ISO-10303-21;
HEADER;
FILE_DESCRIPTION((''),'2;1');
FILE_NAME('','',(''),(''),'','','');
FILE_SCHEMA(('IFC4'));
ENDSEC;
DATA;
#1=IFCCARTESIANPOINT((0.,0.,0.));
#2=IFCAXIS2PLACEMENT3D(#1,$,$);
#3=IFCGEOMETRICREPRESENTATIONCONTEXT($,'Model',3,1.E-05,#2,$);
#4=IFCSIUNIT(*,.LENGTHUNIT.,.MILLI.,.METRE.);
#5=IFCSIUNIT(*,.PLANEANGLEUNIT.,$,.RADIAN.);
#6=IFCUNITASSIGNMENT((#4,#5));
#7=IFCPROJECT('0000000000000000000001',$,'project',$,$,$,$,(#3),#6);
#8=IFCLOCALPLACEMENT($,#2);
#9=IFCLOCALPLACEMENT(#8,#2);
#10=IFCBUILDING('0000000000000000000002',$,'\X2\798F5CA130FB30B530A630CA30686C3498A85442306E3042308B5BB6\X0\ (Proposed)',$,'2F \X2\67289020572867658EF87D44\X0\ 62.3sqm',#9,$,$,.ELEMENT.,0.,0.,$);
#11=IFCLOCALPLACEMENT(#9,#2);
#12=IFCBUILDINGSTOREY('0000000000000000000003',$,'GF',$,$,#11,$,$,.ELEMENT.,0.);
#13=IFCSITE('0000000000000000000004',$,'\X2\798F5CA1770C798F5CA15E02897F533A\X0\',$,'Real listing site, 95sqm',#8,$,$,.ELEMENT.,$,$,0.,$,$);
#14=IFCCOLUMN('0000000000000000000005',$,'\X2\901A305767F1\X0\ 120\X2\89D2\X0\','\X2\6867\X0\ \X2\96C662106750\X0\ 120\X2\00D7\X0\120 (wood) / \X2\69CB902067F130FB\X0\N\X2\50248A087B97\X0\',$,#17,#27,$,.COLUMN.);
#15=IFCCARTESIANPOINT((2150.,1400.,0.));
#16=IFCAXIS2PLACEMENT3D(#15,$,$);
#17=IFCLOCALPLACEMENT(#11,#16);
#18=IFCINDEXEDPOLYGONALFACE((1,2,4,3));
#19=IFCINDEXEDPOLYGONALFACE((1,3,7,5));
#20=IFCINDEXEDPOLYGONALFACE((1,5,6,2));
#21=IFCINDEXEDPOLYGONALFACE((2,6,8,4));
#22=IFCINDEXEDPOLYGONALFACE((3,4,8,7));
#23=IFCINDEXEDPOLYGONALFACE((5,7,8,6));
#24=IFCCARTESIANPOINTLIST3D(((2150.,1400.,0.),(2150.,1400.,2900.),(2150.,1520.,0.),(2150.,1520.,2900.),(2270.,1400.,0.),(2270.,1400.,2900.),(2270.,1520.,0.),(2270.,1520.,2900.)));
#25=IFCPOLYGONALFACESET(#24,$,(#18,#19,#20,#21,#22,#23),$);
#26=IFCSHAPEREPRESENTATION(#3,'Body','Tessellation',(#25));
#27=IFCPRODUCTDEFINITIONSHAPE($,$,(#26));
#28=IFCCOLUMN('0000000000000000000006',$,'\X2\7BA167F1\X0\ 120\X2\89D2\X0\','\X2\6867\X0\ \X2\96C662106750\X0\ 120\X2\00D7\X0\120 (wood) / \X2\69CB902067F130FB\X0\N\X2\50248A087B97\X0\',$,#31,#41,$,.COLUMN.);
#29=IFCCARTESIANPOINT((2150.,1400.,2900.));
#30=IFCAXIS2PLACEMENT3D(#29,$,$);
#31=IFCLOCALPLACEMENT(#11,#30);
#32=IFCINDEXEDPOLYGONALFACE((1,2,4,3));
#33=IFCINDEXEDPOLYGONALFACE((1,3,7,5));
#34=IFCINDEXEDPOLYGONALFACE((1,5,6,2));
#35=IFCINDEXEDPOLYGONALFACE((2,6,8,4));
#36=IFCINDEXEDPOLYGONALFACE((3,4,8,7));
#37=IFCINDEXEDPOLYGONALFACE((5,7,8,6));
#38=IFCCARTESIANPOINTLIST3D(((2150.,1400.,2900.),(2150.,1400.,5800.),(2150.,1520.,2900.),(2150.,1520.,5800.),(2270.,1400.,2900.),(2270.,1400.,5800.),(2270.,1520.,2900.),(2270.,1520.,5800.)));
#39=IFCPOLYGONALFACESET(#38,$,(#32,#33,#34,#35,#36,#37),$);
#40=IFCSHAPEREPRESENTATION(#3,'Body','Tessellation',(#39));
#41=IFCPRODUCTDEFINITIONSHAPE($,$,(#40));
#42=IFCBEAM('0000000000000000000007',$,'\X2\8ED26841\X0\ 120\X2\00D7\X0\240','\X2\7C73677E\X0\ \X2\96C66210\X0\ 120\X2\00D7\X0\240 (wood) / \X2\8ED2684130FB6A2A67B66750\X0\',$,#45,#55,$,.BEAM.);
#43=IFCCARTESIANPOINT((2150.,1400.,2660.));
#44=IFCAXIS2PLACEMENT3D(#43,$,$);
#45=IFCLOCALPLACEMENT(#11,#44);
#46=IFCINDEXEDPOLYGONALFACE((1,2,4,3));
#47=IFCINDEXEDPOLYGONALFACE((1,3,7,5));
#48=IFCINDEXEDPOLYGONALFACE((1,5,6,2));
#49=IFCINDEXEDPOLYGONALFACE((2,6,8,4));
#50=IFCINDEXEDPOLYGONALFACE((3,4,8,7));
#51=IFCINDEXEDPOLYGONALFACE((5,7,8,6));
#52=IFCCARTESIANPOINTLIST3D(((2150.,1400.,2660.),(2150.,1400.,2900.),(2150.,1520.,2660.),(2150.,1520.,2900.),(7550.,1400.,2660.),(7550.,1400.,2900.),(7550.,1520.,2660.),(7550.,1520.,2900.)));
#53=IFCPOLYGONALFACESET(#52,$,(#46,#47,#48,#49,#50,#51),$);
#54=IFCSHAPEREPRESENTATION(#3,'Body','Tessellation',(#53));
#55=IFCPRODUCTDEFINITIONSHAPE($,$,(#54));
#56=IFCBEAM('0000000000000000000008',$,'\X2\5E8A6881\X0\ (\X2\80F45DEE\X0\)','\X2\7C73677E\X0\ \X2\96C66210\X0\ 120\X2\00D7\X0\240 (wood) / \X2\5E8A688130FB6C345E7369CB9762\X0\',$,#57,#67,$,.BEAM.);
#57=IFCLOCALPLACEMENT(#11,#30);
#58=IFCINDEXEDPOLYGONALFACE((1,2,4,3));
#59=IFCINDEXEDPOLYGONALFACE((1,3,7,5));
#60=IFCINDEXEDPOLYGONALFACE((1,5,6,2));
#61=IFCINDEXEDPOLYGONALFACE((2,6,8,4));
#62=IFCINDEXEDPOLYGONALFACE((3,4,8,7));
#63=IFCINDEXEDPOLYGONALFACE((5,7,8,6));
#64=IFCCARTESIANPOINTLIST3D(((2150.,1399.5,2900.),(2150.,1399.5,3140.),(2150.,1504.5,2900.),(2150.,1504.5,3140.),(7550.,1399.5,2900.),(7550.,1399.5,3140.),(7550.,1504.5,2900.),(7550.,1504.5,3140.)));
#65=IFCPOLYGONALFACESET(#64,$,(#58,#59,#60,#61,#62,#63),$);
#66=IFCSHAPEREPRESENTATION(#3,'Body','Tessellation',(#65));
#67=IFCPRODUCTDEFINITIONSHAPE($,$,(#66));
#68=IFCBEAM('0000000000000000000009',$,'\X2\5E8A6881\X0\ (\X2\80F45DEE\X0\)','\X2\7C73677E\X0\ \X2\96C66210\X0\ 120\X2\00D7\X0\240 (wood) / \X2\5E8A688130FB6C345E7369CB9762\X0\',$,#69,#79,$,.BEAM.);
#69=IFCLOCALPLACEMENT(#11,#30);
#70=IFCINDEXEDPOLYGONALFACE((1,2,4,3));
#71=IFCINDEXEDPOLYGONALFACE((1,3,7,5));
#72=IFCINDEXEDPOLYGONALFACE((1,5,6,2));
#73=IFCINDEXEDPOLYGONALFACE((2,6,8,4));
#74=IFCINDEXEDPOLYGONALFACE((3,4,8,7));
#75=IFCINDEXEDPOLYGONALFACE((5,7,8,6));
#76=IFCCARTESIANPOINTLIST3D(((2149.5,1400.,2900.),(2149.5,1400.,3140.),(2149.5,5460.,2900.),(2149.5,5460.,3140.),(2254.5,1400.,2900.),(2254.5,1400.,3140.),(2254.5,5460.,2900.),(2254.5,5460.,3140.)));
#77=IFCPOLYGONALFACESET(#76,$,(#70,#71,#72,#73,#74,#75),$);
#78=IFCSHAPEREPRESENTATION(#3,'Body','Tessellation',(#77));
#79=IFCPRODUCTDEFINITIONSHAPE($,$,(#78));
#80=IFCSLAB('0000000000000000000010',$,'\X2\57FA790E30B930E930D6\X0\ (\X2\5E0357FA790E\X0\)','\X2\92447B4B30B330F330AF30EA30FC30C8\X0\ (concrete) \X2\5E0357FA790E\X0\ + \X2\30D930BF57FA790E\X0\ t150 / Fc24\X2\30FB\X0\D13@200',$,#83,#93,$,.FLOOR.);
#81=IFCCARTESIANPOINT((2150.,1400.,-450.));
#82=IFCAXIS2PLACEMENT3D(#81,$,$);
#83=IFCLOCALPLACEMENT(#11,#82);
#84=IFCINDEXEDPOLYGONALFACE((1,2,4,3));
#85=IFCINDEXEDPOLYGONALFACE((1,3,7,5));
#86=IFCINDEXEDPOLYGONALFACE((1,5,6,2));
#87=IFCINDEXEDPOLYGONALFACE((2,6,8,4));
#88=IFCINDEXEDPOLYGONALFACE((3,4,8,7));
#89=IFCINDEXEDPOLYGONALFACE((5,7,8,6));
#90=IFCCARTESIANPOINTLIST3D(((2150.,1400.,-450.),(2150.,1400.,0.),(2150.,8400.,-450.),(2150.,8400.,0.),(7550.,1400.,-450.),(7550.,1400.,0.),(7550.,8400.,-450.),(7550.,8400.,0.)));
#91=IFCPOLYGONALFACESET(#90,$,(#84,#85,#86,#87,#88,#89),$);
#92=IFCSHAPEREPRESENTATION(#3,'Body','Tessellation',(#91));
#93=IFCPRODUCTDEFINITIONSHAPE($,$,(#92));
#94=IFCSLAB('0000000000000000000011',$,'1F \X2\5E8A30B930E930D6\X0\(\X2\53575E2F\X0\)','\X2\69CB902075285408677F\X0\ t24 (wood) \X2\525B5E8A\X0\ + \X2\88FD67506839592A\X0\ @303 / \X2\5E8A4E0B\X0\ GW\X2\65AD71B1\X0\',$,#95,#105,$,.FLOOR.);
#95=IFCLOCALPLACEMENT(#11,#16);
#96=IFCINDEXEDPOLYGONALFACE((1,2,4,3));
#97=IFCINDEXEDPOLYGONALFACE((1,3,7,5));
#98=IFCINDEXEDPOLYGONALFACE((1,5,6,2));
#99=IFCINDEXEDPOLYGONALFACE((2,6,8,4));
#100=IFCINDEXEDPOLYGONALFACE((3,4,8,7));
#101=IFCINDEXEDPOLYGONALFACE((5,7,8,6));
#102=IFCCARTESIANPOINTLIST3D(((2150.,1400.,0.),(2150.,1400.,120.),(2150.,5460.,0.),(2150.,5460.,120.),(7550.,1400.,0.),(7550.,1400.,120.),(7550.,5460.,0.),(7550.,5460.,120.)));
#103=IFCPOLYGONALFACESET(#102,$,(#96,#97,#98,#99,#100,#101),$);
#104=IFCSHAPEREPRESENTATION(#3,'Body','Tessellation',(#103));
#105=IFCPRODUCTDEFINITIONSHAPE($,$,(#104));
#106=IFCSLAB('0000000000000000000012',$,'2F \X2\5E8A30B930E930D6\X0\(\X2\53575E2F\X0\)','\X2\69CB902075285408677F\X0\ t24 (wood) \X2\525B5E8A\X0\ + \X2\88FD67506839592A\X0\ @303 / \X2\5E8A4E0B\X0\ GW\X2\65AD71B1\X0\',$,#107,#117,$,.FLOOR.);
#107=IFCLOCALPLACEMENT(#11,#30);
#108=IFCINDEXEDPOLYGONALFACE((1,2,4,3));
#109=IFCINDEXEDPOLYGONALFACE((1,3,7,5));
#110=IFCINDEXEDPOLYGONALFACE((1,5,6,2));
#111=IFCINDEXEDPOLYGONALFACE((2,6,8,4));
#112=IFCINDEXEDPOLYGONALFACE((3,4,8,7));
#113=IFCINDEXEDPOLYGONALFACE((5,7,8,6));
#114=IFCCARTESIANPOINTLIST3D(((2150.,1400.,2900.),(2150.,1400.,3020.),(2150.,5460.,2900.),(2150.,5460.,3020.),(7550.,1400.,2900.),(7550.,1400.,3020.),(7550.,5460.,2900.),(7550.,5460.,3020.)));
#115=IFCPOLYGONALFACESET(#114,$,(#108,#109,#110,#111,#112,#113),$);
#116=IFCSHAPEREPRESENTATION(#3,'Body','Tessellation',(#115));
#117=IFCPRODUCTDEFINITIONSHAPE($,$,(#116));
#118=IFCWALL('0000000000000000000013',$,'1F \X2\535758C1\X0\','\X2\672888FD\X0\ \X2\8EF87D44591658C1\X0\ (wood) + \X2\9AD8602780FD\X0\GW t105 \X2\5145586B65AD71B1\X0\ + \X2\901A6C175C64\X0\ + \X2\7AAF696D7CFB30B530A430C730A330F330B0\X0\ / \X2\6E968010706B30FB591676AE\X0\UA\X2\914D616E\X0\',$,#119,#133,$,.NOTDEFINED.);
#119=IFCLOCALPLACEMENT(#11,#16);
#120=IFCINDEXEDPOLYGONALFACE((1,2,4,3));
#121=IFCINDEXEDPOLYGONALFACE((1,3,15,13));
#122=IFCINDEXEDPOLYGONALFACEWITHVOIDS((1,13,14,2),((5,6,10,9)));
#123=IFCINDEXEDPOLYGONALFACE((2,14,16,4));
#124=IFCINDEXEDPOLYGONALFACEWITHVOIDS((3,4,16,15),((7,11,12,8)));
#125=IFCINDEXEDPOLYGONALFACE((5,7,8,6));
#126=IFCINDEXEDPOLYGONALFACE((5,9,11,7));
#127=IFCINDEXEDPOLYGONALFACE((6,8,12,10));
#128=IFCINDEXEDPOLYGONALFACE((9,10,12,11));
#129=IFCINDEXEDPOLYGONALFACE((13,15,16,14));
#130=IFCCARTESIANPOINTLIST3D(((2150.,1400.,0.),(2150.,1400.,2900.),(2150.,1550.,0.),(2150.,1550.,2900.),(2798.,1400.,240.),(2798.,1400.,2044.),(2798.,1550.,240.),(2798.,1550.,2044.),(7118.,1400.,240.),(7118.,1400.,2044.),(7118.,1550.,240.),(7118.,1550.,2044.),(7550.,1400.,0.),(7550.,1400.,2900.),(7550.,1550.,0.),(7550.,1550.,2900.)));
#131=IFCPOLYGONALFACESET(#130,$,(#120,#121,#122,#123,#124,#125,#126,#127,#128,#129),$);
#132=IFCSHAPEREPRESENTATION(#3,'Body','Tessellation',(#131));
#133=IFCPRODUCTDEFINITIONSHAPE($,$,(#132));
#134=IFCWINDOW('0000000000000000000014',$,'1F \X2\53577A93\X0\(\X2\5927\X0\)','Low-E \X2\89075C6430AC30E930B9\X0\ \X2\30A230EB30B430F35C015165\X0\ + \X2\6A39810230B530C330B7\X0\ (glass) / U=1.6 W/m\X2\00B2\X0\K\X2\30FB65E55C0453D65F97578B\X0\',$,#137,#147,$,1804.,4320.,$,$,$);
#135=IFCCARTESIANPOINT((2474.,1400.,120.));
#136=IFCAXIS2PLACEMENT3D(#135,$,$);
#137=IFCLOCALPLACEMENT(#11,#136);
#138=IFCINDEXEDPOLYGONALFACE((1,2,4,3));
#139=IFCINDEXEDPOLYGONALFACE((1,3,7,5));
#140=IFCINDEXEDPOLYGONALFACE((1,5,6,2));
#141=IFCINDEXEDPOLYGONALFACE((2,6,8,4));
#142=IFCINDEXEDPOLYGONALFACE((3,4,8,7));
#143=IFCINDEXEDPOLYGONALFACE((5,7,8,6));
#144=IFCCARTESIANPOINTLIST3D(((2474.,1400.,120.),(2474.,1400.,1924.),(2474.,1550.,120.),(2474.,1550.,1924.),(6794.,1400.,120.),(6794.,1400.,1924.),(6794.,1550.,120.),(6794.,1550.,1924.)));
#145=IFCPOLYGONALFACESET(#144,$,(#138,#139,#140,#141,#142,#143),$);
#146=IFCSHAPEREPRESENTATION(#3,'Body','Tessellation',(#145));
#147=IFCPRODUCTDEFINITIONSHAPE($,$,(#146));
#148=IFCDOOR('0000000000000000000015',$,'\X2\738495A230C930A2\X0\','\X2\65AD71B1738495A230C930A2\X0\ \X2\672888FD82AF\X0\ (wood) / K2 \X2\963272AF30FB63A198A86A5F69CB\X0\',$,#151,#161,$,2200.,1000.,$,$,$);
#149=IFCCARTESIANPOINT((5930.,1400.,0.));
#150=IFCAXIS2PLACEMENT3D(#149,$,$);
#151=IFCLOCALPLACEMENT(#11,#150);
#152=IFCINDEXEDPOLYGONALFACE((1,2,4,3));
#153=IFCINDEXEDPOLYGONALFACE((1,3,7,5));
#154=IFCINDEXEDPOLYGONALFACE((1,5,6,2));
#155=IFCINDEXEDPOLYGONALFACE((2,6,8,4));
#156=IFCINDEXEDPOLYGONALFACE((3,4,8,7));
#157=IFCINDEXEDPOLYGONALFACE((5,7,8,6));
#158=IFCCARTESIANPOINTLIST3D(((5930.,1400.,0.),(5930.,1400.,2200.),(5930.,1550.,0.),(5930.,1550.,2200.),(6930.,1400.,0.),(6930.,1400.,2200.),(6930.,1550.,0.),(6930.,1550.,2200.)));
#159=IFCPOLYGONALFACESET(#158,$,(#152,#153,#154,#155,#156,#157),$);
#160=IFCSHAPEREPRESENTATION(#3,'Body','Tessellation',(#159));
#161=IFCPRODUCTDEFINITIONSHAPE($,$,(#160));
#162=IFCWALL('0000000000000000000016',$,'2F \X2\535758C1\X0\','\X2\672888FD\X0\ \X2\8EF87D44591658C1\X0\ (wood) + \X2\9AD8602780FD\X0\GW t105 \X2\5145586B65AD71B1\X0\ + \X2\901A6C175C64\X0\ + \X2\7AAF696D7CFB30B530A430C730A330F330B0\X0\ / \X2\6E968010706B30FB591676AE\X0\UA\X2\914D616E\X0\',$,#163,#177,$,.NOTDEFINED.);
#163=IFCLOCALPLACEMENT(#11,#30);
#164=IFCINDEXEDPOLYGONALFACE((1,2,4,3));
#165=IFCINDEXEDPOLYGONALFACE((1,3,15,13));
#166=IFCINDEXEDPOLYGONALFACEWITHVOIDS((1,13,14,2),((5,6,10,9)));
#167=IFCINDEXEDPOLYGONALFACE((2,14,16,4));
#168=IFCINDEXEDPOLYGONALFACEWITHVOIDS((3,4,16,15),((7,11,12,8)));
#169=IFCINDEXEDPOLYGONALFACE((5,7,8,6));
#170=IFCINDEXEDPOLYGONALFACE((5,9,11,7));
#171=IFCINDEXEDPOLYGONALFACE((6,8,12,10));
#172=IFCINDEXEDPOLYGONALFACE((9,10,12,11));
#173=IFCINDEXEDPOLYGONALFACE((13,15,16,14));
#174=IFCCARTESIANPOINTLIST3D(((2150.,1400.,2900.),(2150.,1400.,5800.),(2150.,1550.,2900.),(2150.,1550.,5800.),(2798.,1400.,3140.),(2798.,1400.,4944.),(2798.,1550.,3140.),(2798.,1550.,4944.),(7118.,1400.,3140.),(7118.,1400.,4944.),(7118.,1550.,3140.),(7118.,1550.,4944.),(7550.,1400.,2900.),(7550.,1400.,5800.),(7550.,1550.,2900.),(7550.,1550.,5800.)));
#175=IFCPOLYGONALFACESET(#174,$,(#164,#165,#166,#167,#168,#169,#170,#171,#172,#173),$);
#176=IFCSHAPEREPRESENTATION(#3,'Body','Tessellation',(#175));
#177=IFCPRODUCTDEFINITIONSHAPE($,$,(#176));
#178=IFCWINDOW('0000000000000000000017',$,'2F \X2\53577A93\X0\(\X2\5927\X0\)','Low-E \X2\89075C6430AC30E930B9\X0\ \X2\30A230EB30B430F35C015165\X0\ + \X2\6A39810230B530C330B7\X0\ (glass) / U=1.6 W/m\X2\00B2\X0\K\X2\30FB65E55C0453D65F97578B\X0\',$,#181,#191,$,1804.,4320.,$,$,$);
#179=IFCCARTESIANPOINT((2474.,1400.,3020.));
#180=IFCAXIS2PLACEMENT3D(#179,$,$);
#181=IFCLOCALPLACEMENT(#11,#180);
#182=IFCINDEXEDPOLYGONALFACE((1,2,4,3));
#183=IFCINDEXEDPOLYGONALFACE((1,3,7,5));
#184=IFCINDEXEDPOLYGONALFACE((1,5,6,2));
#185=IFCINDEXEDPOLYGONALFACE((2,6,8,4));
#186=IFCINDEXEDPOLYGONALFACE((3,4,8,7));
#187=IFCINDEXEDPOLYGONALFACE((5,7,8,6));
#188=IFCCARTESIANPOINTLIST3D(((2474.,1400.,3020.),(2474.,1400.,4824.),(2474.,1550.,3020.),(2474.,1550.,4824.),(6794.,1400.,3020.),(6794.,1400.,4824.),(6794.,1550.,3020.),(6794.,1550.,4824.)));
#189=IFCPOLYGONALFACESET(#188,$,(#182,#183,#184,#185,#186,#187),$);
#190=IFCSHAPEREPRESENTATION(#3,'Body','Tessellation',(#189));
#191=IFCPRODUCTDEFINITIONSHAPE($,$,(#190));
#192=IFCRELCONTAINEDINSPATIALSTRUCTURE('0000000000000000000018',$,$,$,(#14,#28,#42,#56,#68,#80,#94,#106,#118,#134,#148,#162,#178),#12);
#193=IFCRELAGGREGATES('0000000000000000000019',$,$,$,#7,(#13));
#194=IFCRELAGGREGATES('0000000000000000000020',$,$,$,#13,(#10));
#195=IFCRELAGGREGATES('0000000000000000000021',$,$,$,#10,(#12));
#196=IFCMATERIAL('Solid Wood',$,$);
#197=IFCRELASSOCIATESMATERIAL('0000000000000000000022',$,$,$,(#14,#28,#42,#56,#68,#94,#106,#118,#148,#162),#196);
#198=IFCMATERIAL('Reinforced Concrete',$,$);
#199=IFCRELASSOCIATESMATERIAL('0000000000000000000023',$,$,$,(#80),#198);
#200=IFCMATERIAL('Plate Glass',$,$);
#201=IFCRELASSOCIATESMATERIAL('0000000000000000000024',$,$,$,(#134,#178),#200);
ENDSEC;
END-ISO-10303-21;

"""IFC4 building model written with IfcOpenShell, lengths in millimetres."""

from ifc_helpers import new_model, si_unit, frame, frame_2d, origin, place, context, project, spatial, rectangle, extrude, material, element, fill, save


model = new_model("IFC4")

# Units and contexts
model_context = context("Model", 3, precision=1e-05, world=origin())
ifc_project = project(units=[si_unit("LENGTHUNIT", "METRE", prefix="MILLI"), si_unit("PLANEANGLEUNIT", "RADIAN")], contexts=[model_context])

# Site, building, storey
site_placement = place(None, origin())
site = spatial("IfcSite", under=ifc_project, at=site_placement, Name="福岡県福岡市西区", ObjectType="Real listing site, 95sqm", CompositionType="ELEMENT", RefElevation=0.0)
building_placement = place(site_placement, origin())
building = spatial("IfcBuilding", under=site, at=building_placement, Name="福岡・サウナと水風呂のある家 (Proposed)", ObjectType="2F 木造在来軸組 62.3sqm", CompositionType="ELEMENT", ElevationOfRefHeight=0.0, ElevationOfTerrain=0.0)
storey_placement = place(building_placement, origin())
storey = spatial("IfcBuildingStorey", under=building, at=storey_placement, Name="GF", CompositionType="ELEMENT", Elevation=0.0)

# Columns
ifc_material_1 = material(Name="Solid Wood")
column_1_placement = place(storey_placement, frame((2150.0, 1400.0, 0.0)))
element("IfcColumn", 1, at=column_1_placement, inside=storey, material=ifc_material_1, Name="通し柱 120角", Description="桧 集成材 120×120 (wood) / 構造柱・N値計算", PredefinedType="COLUMN", context=model_context, shape_type="SweptSolid", body=[
    extrude(rectangle(XDim=120.0, YDim=120.0, at=frame_2d((60.0, 60.0))), frame((2150.0, 1400.0, 0.0)), (0.0, 0.0, 1.0), 2900.0),
])
column_2_placement = place(storey_placement, frame((2150.0, 1400.0, 2900.0)))
element("IfcColumn", 2, at=column_2_placement, inside=storey, material=ifc_material_1, Name="管柱 120角", Description="桧 集成材 120×120 (wood) / 構造柱・N値計算", PredefinedType="COLUMN", context=model_context, shape_type="SweptSolid", body=[
    extrude(rectangle(XDim=120.0, YDim=120.0, at=frame_2d((60.0, 60.0))), frame((2150.0, 1400.0, 2900.0)), (0.0, 0.0, 1.0), 2900.0),
])

# Beams
beam_1_placement = place(storey_placement, frame((2150.0, 1400.0, 2660.0)))
element("IfcBeam", 3, at=beam_1_placement, inside=storey, material=ifc_material_1, Name="軒桁 120×240", Description="米松 集成 120×240 (wood) / 軒桁・横架材", PredefinedType="BEAM", context=model_context, shape_type="SweptSolid", body=[
    extrude(rectangle(XDim=5400.0, YDim=120.0, at=frame_2d((2700.0, 60.0))), frame((2150.0, 1400.0, 2660.0)), (0.0, 0.0, 1.0), 240.0),
])
beam_2_placement = place(storey_placement, frame((2150.0, 1400.0, 2900.0)))
element("IfcBeam", 4, at=beam_2_placement, inside=storey, material=ifc_material_1, Name="床梁 (胴差)", Description="米松 集成 120×240 (wood) / 床梁・水平構面", PredefinedType="BEAM", context=model_context, shape_type="SweptSolid", body=[
    extrude(rectangle(XDim=5400.0, YDim=105.0, at=frame_2d((2700.0, 52.0))), frame((2150.0, 1400.0, 2900.0)), (0.0, 0.0, 1.0), 240.0),
])
beam_3_placement = place(storey_placement, frame((2150.0, 1400.0, 2900.0)))
element("IfcBeam", 5, at=beam_3_placement, inside=storey, material=ifc_material_1, Name="床梁 (胴差)", Description="米松 集成 120×240 (wood) / 床梁・水平構面", PredefinedType="BEAM", context=model_context, shape_type="SweptSolid", body=[
    extrude(rectangle(XDim=105.0, YDim=4060.0, at=frame_2d((52.0, 2030.0))), frame((2150.0, 1400.0, 2900.0)), (0.0, 0.0, 1.0), 240.0),
])

# Slabs
ifc_material_2 = material(Name="Reinforced Concrete")
slab_1_placement = place(storey_placement, frame((2150.0, 1400.0, -450.0)))
element("IfcSlab", 6, at=slab_1_placement, inside=storey, material=ifc_material_2, Name="基礎スラブ (布基礎)", Description="鉄筋コンクリート (concrete) 布基礎 + ベタ基礎 t150 / Fc24・D13@200", PredefinedType="FLOOR", context=model_context, shape_type="SweptSolid", body=[
    extrude(rectangle(XDim=5400.0, YDim=7000.0, at=frame_2d((2700.0, 3500.0))), frame((2150.0, 1400.0, -450.0)), (0.0, 0.0, 1.0), 450.0),
])
slab_2_placement = place(storey_placement, frame((2150.0, 1400.0, 0.0)))
element("IfcSlab", 7, at=slab_2_placement, inside=storey, material=ifc_material_1, Name="1F 床スラブ(南帯)", Description="構造用合板 t24 (wood) 剛床 + 製材根太 @303 / 床下 GW断熱", PredefinedType="FLOOR", context=model_context, shape_type="SweptSolid", body=[
    extrude(rectangle(XDim=5400.0, YDim=4060.0, at=frame_2d((2700.0, 2030.0))), frame((2150.0, 1400.0, 0.0)), (0.0, 0.0, 1.0), 120.0),
])
slab_3_placement = place(storey_placement, frame((2150.0, 1400.0, 2900.0)))
element("IfcSlab", 8, at=slab_3_placement, inside=storey, material=ifc_material_1, Name="2F 床スラブ(南帯)", Description="構造用合板 t24 (wood) 剛床 + 製材根太 @303 / 床下 GW断熱", PredefinedType="FLOOR", context=model_context, shape_type="SweptSolid", body=[
    extrude(rectangle(XDim=5400.0, YDim=4060.0, at=frame_2d((2700.0, 2030.0))), frame((2150.0, 1400.0, 2900.0)), (0.0, 0.0, 1.0), 120.0),
])

# Wall, openings, window, door
wall_1_placement = place(storey_placement, frame((2150.0, 1400.0, 0.0)))
wall_1 = element("IfcWall", 9, at=wall_1_placement, inside=storey, material=ifc_material_1, Name="1F 南壁", Description="木製 軸組外壁 (wood) + 高性能GW t105 充填断熱 + 通気層 + 窯業系サイディング / 準耐火・外皮UA配慮", PredefinedType="NOTDEFINED", context=model_context, shape_type="SweptSolid", body=[
    extrude(rectangle(XDim=5400.0, YDim=150.0, at=frame_2d((2700.0, 75.0))), frame((2150.0, 1400.0, 0.0)), (0.0, 0.0, 1.0), 2900.0),
])
opening_1_placement = place(storey_placement, frame((2474.0, 1400.0, 120.0)))
opening_1 = element("IfcOpeningElement", 10, at=opening_1_placement, cuts=wall_1, PredefinedType="NOTDEFINED", context=model_context, shape_type="SweptSolid", body=[
    extrude(rectangle(XDim=4320.0, YDim=150.0, at=frame_2d((2160.0, 75.0))), frame((2474.0, 1400.0, 120.0)), (0.0, 0.0, 1.0), 1804.0),
])
opening_2_placement = place(storey_placement, frame((5930.0, 1400.0, 0.0)))
opening_2 = element("IfcOpeningElement", 11, at=opening_2_placement, cuts=wall_1, PredefinedType="NOTDEFINED", context=model_context, shape_type="SweptSolid", body=[
    extrude(rectangle(XDim=1000.0, YDim=150.0, at=frame_2d((500.0, 75.0))), frame((5930.0, 1400.0, 0.0)), (0.0, 0.0, 1.0), 2200.0),
])
ifc_material_3 = material(Name="Plate Glass")
window_1_placement = place(storey_placement, frame((2474.0, 1400.0, 120.0)))
window_1 = element("IfcWindow", 12, at=window_1_placement, inside=storey, material=ifc_material_3, Name="1F 南窓(大)", Description="Low-E 複層ガラス アルゴン封入 + 樹脂サッシ (glass) / U=1.6 W/m²K・日射取得型", OverallHeight=1804.0, OverallWidth=4320.0, context=model_context, shape_type="SweptSolid", body=[
    extrude(rectangle(XDim=4320.0, YDim=150.0, at=frame_2d((2160.0, 75.0))), frame((2474.0, 1400.0, 120.0)), (0.0, 0.0, 1.0), 1804.0),
])
fill(opening_1, window_1)
door_placement = place(storey_placement, frame((5930.0, 1400.0, 0.0)))
door = element("IfcDoor", 13, at=door_placement, inside=storey, material=ifc_material_1, Name="玄関ドア", Description="断熱玄関ドア 木製芯 (wood) / K2 防犯・採風機構", OverallHeight=2200.0, OverallWidth=1000.0, context=model_context, shape_type="SweptSolid", body=[
    extrude(rectangle(XDim=1000.0, YDim=150.0, at=frame_2d((500.0, 75.0))), frame((5930.0, 1400.0, 0.0)), (0.0, 0.0, 1.0), 2200.0),
])
fill(opening_2, door)

# Wall, opening, window
wall_2_placement = place(storey_placement, frame((2150.0, 1400.0, 2900.0)))
wall_2 = element("IfcWall", 14, at=wall_2_placement, inside=storey, material=ifc_material_1, Name="2F 南壁", Description="木製 軸組外壁 (wood) + 高性能GW t105 充填断熱 + 通気層 + 窯業系サイディング / 準耐火・外皮UA配慮", PredefinedType="NOTDEFINED", context=model_context, shape_type="SweptSolid", body=[
    extrude(rectangle(XDim=5400.0, YDim=150.0, at=frame_2d((2700.0, 75.0))), frame((2150.0, 1400.0, 2900.0)), (0.0, 0.0, 1.0), 2900.0),
])
opening_3_placement = place(storey_placement, frame((2474.0, 1400.0, 3020.0)))
opening_3 = element("IfcOpeningElement", 15, at=opening_3_placement, cuts=wall_2, PredefinedType="NOTDEFINED", context=model_context, shape_type="SweptSolid", body=[
    extrude(rectangle(XDim=4320.0, YDim=150.0, at=frame_2d((2160.0, 75.0))), frame((2474.0, 1400.0, 3020.0)), (0.0, 0.0, 1.0), 1804.0),
])
window_2_placement = place(storey_placement, frame((2474.0, 1400.0, 3020.0)))
window_2 = element("IfcWindow", 16, at=window_2_placement, inside=storey, material=ifc_material_3, Name="2F 南窓(大)", Description="Low-E 複層ガラス アルゴン封入 + 樹脂サッシ (glass) / U=1.6 W/m²K・日射取得型", OverallHeight=1804.0, OverallWidth=4320.0, context=model_context, shape_type="SweptSolid", body=[
    extrude(rectangle(XDim=4320.0, YDim=150.0, at=frame_2d((2160.0, 75.0))), frame((2474.0, 1400.0, 3020.0)), (0.0, 0.0, 1.0), 1804.0),
])
fill(opening_3, window_2)

save(model, "model.ifc")
